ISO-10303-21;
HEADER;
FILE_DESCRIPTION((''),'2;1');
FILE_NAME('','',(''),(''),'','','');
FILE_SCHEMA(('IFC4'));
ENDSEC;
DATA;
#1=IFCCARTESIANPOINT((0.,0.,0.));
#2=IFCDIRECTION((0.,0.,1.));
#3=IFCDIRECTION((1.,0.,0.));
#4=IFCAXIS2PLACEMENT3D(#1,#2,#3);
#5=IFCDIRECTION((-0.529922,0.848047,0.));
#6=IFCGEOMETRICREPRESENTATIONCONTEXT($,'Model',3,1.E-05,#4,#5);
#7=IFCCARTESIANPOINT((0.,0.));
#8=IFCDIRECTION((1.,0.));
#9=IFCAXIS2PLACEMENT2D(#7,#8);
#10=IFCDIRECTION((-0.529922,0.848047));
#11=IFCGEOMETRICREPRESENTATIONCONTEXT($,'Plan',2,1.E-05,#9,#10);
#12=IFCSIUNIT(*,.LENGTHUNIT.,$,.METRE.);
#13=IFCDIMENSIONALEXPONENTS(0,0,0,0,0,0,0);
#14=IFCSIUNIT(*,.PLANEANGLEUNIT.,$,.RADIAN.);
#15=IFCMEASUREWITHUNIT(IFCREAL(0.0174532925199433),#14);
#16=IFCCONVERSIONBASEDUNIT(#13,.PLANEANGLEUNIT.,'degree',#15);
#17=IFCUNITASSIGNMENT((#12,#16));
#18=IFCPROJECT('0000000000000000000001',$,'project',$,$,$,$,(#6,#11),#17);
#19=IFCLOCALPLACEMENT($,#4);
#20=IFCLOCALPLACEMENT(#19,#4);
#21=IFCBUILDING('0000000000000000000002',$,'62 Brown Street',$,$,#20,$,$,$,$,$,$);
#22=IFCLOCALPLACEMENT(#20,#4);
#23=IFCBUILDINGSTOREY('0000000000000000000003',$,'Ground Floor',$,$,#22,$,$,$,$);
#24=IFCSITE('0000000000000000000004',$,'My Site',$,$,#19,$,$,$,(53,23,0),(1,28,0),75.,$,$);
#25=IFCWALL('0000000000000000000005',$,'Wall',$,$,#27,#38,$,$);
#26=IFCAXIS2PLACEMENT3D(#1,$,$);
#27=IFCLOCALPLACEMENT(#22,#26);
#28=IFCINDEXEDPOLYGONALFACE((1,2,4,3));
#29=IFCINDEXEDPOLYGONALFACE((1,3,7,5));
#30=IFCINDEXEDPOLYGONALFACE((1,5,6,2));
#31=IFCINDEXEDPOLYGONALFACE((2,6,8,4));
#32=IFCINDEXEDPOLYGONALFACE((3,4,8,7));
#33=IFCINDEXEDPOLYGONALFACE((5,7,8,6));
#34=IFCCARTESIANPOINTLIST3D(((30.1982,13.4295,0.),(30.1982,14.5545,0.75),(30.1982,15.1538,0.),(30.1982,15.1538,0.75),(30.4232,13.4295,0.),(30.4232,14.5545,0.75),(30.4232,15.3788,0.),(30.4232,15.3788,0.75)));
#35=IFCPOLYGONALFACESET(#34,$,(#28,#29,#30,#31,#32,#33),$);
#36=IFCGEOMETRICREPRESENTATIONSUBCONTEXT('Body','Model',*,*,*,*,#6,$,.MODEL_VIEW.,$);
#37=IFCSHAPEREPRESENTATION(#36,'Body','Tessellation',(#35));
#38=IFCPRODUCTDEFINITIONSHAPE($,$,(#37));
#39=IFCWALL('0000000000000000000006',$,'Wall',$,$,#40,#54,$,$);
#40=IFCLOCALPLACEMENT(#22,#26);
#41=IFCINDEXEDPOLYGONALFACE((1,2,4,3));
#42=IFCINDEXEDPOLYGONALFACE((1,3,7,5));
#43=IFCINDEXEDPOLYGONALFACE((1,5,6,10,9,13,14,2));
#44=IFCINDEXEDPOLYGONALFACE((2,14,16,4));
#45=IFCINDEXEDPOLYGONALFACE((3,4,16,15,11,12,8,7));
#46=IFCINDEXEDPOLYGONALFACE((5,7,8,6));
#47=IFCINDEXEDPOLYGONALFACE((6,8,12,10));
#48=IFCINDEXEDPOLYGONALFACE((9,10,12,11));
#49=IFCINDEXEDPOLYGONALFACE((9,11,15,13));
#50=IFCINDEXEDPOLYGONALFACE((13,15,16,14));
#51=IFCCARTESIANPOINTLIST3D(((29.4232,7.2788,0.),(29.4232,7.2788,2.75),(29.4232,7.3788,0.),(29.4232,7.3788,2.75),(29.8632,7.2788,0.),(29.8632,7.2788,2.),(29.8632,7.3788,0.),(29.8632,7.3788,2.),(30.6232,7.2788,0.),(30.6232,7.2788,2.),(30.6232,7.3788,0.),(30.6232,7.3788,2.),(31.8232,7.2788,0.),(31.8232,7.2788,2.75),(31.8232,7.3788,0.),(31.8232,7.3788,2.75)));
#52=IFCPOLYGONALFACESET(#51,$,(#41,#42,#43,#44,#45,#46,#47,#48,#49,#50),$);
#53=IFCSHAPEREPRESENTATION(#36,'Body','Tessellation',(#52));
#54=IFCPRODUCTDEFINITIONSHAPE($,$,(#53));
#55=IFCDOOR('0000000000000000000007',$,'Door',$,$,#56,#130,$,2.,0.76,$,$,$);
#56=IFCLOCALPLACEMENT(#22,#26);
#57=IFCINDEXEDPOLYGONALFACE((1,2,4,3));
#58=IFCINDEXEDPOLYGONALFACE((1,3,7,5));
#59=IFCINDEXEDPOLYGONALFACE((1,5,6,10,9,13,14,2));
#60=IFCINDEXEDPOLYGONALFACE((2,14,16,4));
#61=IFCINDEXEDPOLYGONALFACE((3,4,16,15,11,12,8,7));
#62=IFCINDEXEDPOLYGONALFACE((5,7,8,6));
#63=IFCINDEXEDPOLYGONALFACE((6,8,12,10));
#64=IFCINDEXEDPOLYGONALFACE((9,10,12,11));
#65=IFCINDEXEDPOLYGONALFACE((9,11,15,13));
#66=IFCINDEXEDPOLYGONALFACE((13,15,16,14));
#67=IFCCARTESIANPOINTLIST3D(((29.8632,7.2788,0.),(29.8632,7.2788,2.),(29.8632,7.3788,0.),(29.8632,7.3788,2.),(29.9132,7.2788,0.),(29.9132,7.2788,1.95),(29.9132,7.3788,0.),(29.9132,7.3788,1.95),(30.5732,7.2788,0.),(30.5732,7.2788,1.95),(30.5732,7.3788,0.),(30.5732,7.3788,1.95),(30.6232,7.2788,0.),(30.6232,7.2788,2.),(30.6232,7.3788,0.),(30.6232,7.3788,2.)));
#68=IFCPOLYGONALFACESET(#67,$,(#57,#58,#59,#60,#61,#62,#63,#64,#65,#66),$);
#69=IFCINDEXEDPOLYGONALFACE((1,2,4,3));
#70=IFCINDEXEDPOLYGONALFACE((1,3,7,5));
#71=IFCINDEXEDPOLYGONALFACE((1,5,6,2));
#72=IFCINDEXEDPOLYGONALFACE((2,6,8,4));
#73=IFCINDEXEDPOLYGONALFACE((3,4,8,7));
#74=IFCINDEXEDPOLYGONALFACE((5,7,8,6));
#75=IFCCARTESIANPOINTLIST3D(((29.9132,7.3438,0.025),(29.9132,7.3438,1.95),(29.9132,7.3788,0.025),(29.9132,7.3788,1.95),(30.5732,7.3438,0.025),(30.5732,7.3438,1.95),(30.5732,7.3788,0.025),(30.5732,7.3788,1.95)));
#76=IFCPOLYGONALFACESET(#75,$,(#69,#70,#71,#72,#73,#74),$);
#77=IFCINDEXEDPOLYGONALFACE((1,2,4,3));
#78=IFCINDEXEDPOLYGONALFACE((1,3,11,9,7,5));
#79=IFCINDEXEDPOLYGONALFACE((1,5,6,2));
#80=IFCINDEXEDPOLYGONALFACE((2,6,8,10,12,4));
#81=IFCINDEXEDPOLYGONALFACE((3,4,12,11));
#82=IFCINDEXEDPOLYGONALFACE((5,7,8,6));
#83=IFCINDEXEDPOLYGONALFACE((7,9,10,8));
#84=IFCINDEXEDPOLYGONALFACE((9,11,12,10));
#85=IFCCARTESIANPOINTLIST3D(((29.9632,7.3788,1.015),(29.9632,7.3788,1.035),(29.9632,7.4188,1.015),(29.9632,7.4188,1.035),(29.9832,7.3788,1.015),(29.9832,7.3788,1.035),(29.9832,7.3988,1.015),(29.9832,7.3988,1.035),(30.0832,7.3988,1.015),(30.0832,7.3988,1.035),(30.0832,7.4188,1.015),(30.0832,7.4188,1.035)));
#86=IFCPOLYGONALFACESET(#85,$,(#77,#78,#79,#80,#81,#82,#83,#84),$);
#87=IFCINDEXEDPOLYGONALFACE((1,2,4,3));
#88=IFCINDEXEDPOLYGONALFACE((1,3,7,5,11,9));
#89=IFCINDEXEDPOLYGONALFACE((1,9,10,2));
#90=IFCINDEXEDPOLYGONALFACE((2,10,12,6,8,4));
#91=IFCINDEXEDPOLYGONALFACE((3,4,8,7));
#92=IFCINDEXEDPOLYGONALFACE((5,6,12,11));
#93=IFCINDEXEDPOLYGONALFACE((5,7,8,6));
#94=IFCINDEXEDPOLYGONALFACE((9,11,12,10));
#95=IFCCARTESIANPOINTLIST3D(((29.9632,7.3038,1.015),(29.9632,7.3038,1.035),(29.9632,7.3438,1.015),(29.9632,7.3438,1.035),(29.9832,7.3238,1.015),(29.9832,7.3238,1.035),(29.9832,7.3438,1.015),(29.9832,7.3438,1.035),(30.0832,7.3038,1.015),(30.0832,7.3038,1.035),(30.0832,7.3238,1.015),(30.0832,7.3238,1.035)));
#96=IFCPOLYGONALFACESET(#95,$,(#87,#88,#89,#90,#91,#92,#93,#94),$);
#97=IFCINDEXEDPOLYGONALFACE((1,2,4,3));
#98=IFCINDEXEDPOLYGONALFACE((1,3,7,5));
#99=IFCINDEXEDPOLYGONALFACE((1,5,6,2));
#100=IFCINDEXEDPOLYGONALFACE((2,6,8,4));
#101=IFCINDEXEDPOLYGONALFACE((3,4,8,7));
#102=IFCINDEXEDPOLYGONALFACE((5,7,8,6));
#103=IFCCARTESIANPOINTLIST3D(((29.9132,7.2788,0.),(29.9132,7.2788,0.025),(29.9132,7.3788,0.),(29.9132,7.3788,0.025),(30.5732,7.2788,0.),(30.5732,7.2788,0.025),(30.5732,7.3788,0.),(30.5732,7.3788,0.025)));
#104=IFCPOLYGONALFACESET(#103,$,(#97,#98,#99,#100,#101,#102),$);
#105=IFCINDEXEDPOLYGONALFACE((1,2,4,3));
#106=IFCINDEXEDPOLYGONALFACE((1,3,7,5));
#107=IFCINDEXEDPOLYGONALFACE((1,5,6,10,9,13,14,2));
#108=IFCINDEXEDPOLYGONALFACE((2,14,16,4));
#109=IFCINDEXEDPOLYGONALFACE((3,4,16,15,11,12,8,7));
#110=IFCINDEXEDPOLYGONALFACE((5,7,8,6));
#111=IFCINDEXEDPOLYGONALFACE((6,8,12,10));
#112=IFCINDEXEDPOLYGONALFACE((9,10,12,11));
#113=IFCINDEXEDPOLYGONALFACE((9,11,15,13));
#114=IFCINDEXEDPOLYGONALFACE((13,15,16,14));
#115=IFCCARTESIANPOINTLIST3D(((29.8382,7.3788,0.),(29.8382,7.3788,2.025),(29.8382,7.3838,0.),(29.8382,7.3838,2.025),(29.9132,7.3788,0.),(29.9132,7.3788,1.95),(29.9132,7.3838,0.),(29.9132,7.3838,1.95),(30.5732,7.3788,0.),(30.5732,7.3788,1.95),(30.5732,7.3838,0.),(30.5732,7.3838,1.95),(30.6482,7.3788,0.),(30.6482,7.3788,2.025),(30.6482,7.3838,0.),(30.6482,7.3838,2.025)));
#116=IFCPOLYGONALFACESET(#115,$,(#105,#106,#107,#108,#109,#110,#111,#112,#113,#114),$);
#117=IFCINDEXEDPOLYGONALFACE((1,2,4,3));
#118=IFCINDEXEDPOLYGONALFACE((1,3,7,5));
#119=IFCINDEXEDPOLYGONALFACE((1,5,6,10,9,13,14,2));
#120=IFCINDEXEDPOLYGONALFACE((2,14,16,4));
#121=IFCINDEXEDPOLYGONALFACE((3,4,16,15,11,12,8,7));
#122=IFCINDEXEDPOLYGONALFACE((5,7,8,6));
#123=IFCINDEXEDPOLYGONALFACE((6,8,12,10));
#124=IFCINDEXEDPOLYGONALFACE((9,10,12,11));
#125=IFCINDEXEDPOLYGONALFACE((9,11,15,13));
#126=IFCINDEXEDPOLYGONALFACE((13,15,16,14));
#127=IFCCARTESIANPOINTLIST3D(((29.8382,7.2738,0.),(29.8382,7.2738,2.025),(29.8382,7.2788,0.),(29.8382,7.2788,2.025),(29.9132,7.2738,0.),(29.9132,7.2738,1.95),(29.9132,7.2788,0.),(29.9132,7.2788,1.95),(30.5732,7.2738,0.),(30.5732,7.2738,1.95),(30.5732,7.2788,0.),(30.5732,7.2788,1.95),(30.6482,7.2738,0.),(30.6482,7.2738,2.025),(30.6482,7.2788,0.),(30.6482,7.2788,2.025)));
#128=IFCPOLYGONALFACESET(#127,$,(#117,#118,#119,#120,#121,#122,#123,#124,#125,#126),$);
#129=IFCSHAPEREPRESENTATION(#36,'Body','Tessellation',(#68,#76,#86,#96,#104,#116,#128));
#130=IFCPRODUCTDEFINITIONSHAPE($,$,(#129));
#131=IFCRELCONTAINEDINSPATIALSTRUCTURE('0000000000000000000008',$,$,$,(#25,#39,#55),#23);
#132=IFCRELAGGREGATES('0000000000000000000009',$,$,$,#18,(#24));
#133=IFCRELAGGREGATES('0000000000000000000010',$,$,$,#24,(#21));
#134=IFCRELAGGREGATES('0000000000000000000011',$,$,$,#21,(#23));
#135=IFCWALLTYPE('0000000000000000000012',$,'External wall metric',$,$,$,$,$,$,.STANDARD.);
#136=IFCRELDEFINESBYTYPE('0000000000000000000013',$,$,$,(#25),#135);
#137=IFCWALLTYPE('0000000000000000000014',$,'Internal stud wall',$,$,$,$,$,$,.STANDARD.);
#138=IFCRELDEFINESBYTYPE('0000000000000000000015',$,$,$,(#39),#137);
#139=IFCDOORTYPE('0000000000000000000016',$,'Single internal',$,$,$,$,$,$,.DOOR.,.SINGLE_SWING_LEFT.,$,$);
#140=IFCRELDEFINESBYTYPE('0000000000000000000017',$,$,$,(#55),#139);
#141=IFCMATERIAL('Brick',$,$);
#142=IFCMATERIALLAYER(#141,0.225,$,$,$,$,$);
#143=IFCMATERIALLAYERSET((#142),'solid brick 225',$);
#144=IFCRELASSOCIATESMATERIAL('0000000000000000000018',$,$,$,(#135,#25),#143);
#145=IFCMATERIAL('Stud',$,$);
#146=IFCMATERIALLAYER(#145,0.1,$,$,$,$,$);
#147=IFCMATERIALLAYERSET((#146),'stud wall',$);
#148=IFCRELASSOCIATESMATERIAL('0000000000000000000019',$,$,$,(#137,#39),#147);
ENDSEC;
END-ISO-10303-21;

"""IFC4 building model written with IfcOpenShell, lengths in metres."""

from ifc_helpers import new_model, entity, si_unit, converted_unit, direction, frame, origin_with_axes, origin_2d_with_axis, place, context, subcontext, project, spatial, line, indexed_curve, outline, extrude, clip, halfspace, shape, source, transform, mapped, material, layer, layer_set, layer_usage, type_object, type_shapes, element, fill, save


model = new_model("IFC4")

# Units and contexts
model_context = context("Model", 3, precision=1e-05, world=origin_with_axes(), true_north=direction((-0.529922, 0.848047, 0.0)))
plan_context = context("Plan", 2, precision=1e-05, world=origin_2d_with_axis(), true_north=direction((-0.529922, 0.848047)))
body_context_1 = subcontext(model_context, "Body", "Model", "MODEL_VIEW")
body_context_2 = subcontext(plan_context, "Body", "Plan", "PLAN_VIEW")
ifc_project = project(units=[si_unit("LENGTHUNIT", "METRE"), converted_unit("PLANEANGLEUNIT", "degree", entity("IfcReal", 0.0174532925199433), si_unit("PLANEANGLEUNIT", "RADIAN"), dimensions=[0, 0, 0, 0, 0, 0, 0])], contexts=[model_context, plan_context])

# Site, building, storey
site_placement = place(None, origin_with_axes())
site = spatial("IfcSite", under=ifc_project, at=site_placement, Name="My Site", RefLatitude=(53, 23, 0), RefLongitude=(1, 28, 0), RefElevation=75.0)
building_placement = place(site_placement, origin_with_axes())
building = spatial("IfcBuilding", under=site, at=building_placement, Name="62 Brown Street")
storey_placement = place(building_placement, origin_with_axes())
storey = spatial("IfcBuildingStorey", under=building, at=storey_placement, Name="Ground Floor")

# Shared definitions
ifc_material_1 = material(Name="Brick")
ifc_layer_1 = layer(ifc_material_1, 0.225)
ifc_layer_set_1 = layer_set([ifc_layer_1], Name="solid brick 225")
wall_type_1 = type_object("IfcWallType", Name="External wall metric", PredefinedType="STANDARD", material=ifc_layer_set_1)

# Wall
ifc_layer_usage_1 = layer_usage(ifc_layer_set_1, "AXIS2", "POSITIVE", 0.0)
wall_1_placement = place(storey_placement, frame((30.4232, 13.4295, 0.0), z_axis=(0.0, 0.0, 1.0), x_axis=(0.0, 1.0, 0.0)))
element("IfcWall", 1, at=wall_1_placement, inside=storey, type_object=wall_type_1, material=ifc_layer_usage_1, Name="Wall", context=body_context_1, shape_type="Clipping", body=[
    clip(clip(extrude(outline(indexed_curve([(0.0, 0.0), (0.0, 0.225), (1.9493, 0.225), (1.9493, 0.0), (0.0, 0.0)], self_intersect=False)), origin_with_axes(), (0.0, 0.0, 1.0), 0.75), halfspace(frame((0.416, 0.5, 0.2774), z_axis=(-0.5547, 0.0, 0.83205), x_axis=(0.0, -1.0, 0.0)), False)), halfspace(frame((1.9493, 0.0, 0.0), z_axis=(0.707107, 0.707107, 0.0), x_axis=(0.707107, -0.707107, 0.0)), False)),
])

# Wall, opening, door
ifc_material_2 = material(Name="Stud")
ifc_layer_2 = layer(ifc_material_2, 0.1)
ifc_layer_set_2 = layer_set([ifc_layer_2], Name="stud wall")
ifc_layer_usage_2 = layer_usage(ifc_layer_set_2, "AXIS2", "POSITIVE", 0.0)
wall_type_2 = type_object("IfcWallType", Name="Internal stud wall", PredefinedType="STANDARD", material=ifc_layer_set_2)
wall_2_placement = place(storey_placement, frame((31.8232, 7.3788, 0.0), z_axis=(0.0, 0.0, 1.0), x_axis=(-1.0, 0.0, 0.0)))
wall_2 = element("IfcWall", 2, at=wall_2_placement, inside=storey, type_object=wall_type_2, material=ifc_layer_usage_2, Name="Wall", context=body_context_1, shape_type="SweptSolid", body=[
    extrude(outline(indexed_curve([(0.0, 0.0), (0.0, 0.1), (2.4, 0.1), (2.4, 0.0), (0.0, 0.0)], self_intersect=False)), origin_with_axes(), (0.0, 0.0, 1.0), 2.75),
])
shared_shape_1 = source(origin_with_axes(), body_context_1, "Body", "SweptSolid", [
    extrude(outline(indexed_curve([(0.0, 0.0), (0.76, 0.0), (0.76, 2.0), (0.0, 2.0)], segments=[line(1, 2, 3, 4, 1)])), frame((0.0, -0.6, 0.0), z_axis=(0.0, -1.0, 0.0), x_axis=(1.0, 0.0, 0.0)), (0.0, 0.0, -1.0), 1.2),
])
opening_1_placement = place(wall_2_placement, frame((1.2, 0.0, 0.0), z_axis=(0.0, 0.0, 1.0), x_axis=(1.0, 0.0, 0.0)))
opening_1 = element("IfcOpeningElement", 3, at=opening_1_placement, cuts=wall_2, PredefinedType="OPENING", context=body_context_1, shape_type="MappedRepresentation", body=[
    mapped(shared_shape_1, transform((0.0, 0.0, 0.0), x_axis=(1.0, 0.0, 0.0), y_axis=(0.0, 1.0, 0.0), z_axis=(0.0, 0.0, 1.0), scale=1.0)),
])
door_type_1 = type_object("IfcDoorType", Name="Single internal", OperationType="SINGLE_SWING_LEFT", PredefinedType="DOOR")
shared_shape_2 = source(origin_with_axes(), body_context_1, "Body", "SweptSolid", [
    extrude(outline(indexed_curve([(0.0, 0.0), (0.0, 2.0), (0.76, 2.0), (0.76, 0.0), (0.71, 0.0), (0.71, 1.95), (0.05, 1.95), (0.05, 0.0)], segments=[line(1, 2, 3, 4, 5, 6, 7, 8, 1)])), frame((0.0, 0.0, 0.0), z_axis=(0.0, -1.0, 0.0), x_axis=(1.0, 0.0, 0.0)), (0.0, 0.0, -1.0), 0.1),
    extrude(outline(indexed_curve([(0.0, 0.0), (0.66, 0.0), (0.66, 0.035), (0.0, 0.035)], segments=[line(1, 2, 3, 4, 1)])), frame((0.05, 0.0, 0.025), z_axis=(0.0, 0.0, 1.0), x_axis=(1.0, 0.0, 0.0)), (0.0, 0.0, 1.0), 1.925),
    extrude(outline(indexed_curve([(0.0, 0.0), (0.0, -0.04), (-0.12, -0.04), (-0.12, -0.02), (-0.02, -0.02), (-0.02, 0.0)], segments=[line(1, 2, 3, 4, 5, 6, 1)])), frame((0.66, 0.0, 1.015), z_axis=(0.0, 0.0, 1.0), x_axis=(1.0, 0.0, 0.0)), (0.0, 0.0, 1.0), 0.02),
    extrude(outline(indexed_curve([(0.0, 0.0), (0.0, 0.04), (-0.12, 0.04), (-0.12, 0.02), (-0.02, 0.02), (-0.02, 0.0)], segments=[line(1, 2, 3, 4, 5, 6, 1)])), frame((0.66, 0.035, 1.015), z_axis=(0.0, 0.0, 1.0), x_axis=(1.0, 0.0, 0.0)), (0.0, 0.0, 1.0), 0.02),
    extrude(outline(indexed_curve([(0.0, 0.0), (0.66, 0.0), (0.66, 0.1), (0.0, 0.1)], segments=[line(1, 2, 3, 4, 1)])), frame((0.05, 0.0, 0.0), z_axis=(0.0, 0.0, 1.0), x_axis=(1.0, 0.0, 0.0)), (0.0, 0.0, 1.0), 0.025),
    extrude(outline(indexed_curve([(0.0, 0.0), (0.0, 2.025), (0.81, 2.025), (0.81, 0.0), (0.735, 0.0), (0.735, 1.95), (0.075, 1.95), (0.075, 0.0)], segments=[line(1, 2, 3, 4, 5, 6, 7, 8, 1)])), frame((-0.025, -0.005, 0.0), z_axis=(0.0, -1.0, 0.0), x_axis=(1.0, 0.0, 0.0)), (0.0, 0.0, -1.0), 0.005),
    extrude(outline(indexed_curve([(0.0, 0.0), (0.0, 2.025), (0.81, 2.025), (0.81, 0.0), (0.735, 0.0), (0.735, 1.95), (0.075, 1.95), (0.075, 0.0)], segments=[line(1, 2, 3, 4, 5, 6, 7, 8, 1)])), frame((-0.025, 0.1, 0.0), z_axis=(0.0, -1.0, 0.0), x_axis=(1.0, 0.0, 0.0)), (0.0, 0.0, -1.0), 0.005),
])
shared_shape_3 = source(origin_with_axes(), body_context_2, "Body", "Curve2D", [
    entity("IfcIndexedPolyCurve", entity("IfcCartesianPointList2D", [[0.0, 0.0], [0.05, 0.0], [0.05, 0.1], [0.0, 0.1]]), [entity("IfcLineIndex", [1, 2, 3, 4, 1])]),
    entity("IfcIndexedPolyCurve", entity("IfcCartesianPointList2D", [[0.76, 0.0], [0.71, 0.0], [0.71, 0.1], [0.76, 0.1]]), [entity("IfcLineIndex", [1, 2, 3, 4, 1])]),
    entity("IfcTrimmedCurve", entity("IfcEllipse", entity("IfcAxis2Placement2D", entity("IfcCartesianPoint", [0.085, 0.1]), entity("IfcDirection", [1.0, 0.0])), 0.625, 0.66), [entity("IfcCartesianPoint", [0.71, 0.1])], [entity("IfcCartesianPoint", [0.085, 0.76])], True, "CARTESIAN"),
    entity("IfcIndexedPolyCurve", entity("IfcCartesianPointList2D", [[0.05, 0.1], [0.085, 0.1], [0.085, 0.76], [0.05, 0.76]]), [entity("IfcLineIndex", [1, 2, 3, 4, 1])]),
])
type_shapes(door_type_1, [shared_shape_2, shared_shape_3])
door_1_placement = place(opening_1_placement, frame((0.0, 0.0, 0.0), z_axis=(0.0, 0.0, 1.0), x_axis=(1.0, 0.0, 0.0)))
door_1 = element("IfcDoor", 4, at=door_1_placement, inside=storey, type_object=door_type_1, Name="Door", OverallHeight=2.0, OverallWidth=0.76, shapes=[
    shape(body_context_1, "Body", "MappedRepresentation", [mapped(shared_shape_2, transform((0.0, 0.0, 0.0), x_axis=(1.0, 0.0, 0.0), y_axis=(0.0, 1.0, 0.0), z_axis=(0.0, 0.0, 1.0), scale=1.0))]),
    shape(body_context_2, "Body", "MappedRepresentation", [mapped(shared_shape_3, transform((0.0, 0.0, 0.0), x_axis=(1.0, 0.0, 0.0), y_axis=(0.0, 1.0, 0.0), z_axis=(0.0, 0.0, 1.0), scale=1.0))]),
])
fill(opening_1, door_1)

save(model, "model.ifc")
